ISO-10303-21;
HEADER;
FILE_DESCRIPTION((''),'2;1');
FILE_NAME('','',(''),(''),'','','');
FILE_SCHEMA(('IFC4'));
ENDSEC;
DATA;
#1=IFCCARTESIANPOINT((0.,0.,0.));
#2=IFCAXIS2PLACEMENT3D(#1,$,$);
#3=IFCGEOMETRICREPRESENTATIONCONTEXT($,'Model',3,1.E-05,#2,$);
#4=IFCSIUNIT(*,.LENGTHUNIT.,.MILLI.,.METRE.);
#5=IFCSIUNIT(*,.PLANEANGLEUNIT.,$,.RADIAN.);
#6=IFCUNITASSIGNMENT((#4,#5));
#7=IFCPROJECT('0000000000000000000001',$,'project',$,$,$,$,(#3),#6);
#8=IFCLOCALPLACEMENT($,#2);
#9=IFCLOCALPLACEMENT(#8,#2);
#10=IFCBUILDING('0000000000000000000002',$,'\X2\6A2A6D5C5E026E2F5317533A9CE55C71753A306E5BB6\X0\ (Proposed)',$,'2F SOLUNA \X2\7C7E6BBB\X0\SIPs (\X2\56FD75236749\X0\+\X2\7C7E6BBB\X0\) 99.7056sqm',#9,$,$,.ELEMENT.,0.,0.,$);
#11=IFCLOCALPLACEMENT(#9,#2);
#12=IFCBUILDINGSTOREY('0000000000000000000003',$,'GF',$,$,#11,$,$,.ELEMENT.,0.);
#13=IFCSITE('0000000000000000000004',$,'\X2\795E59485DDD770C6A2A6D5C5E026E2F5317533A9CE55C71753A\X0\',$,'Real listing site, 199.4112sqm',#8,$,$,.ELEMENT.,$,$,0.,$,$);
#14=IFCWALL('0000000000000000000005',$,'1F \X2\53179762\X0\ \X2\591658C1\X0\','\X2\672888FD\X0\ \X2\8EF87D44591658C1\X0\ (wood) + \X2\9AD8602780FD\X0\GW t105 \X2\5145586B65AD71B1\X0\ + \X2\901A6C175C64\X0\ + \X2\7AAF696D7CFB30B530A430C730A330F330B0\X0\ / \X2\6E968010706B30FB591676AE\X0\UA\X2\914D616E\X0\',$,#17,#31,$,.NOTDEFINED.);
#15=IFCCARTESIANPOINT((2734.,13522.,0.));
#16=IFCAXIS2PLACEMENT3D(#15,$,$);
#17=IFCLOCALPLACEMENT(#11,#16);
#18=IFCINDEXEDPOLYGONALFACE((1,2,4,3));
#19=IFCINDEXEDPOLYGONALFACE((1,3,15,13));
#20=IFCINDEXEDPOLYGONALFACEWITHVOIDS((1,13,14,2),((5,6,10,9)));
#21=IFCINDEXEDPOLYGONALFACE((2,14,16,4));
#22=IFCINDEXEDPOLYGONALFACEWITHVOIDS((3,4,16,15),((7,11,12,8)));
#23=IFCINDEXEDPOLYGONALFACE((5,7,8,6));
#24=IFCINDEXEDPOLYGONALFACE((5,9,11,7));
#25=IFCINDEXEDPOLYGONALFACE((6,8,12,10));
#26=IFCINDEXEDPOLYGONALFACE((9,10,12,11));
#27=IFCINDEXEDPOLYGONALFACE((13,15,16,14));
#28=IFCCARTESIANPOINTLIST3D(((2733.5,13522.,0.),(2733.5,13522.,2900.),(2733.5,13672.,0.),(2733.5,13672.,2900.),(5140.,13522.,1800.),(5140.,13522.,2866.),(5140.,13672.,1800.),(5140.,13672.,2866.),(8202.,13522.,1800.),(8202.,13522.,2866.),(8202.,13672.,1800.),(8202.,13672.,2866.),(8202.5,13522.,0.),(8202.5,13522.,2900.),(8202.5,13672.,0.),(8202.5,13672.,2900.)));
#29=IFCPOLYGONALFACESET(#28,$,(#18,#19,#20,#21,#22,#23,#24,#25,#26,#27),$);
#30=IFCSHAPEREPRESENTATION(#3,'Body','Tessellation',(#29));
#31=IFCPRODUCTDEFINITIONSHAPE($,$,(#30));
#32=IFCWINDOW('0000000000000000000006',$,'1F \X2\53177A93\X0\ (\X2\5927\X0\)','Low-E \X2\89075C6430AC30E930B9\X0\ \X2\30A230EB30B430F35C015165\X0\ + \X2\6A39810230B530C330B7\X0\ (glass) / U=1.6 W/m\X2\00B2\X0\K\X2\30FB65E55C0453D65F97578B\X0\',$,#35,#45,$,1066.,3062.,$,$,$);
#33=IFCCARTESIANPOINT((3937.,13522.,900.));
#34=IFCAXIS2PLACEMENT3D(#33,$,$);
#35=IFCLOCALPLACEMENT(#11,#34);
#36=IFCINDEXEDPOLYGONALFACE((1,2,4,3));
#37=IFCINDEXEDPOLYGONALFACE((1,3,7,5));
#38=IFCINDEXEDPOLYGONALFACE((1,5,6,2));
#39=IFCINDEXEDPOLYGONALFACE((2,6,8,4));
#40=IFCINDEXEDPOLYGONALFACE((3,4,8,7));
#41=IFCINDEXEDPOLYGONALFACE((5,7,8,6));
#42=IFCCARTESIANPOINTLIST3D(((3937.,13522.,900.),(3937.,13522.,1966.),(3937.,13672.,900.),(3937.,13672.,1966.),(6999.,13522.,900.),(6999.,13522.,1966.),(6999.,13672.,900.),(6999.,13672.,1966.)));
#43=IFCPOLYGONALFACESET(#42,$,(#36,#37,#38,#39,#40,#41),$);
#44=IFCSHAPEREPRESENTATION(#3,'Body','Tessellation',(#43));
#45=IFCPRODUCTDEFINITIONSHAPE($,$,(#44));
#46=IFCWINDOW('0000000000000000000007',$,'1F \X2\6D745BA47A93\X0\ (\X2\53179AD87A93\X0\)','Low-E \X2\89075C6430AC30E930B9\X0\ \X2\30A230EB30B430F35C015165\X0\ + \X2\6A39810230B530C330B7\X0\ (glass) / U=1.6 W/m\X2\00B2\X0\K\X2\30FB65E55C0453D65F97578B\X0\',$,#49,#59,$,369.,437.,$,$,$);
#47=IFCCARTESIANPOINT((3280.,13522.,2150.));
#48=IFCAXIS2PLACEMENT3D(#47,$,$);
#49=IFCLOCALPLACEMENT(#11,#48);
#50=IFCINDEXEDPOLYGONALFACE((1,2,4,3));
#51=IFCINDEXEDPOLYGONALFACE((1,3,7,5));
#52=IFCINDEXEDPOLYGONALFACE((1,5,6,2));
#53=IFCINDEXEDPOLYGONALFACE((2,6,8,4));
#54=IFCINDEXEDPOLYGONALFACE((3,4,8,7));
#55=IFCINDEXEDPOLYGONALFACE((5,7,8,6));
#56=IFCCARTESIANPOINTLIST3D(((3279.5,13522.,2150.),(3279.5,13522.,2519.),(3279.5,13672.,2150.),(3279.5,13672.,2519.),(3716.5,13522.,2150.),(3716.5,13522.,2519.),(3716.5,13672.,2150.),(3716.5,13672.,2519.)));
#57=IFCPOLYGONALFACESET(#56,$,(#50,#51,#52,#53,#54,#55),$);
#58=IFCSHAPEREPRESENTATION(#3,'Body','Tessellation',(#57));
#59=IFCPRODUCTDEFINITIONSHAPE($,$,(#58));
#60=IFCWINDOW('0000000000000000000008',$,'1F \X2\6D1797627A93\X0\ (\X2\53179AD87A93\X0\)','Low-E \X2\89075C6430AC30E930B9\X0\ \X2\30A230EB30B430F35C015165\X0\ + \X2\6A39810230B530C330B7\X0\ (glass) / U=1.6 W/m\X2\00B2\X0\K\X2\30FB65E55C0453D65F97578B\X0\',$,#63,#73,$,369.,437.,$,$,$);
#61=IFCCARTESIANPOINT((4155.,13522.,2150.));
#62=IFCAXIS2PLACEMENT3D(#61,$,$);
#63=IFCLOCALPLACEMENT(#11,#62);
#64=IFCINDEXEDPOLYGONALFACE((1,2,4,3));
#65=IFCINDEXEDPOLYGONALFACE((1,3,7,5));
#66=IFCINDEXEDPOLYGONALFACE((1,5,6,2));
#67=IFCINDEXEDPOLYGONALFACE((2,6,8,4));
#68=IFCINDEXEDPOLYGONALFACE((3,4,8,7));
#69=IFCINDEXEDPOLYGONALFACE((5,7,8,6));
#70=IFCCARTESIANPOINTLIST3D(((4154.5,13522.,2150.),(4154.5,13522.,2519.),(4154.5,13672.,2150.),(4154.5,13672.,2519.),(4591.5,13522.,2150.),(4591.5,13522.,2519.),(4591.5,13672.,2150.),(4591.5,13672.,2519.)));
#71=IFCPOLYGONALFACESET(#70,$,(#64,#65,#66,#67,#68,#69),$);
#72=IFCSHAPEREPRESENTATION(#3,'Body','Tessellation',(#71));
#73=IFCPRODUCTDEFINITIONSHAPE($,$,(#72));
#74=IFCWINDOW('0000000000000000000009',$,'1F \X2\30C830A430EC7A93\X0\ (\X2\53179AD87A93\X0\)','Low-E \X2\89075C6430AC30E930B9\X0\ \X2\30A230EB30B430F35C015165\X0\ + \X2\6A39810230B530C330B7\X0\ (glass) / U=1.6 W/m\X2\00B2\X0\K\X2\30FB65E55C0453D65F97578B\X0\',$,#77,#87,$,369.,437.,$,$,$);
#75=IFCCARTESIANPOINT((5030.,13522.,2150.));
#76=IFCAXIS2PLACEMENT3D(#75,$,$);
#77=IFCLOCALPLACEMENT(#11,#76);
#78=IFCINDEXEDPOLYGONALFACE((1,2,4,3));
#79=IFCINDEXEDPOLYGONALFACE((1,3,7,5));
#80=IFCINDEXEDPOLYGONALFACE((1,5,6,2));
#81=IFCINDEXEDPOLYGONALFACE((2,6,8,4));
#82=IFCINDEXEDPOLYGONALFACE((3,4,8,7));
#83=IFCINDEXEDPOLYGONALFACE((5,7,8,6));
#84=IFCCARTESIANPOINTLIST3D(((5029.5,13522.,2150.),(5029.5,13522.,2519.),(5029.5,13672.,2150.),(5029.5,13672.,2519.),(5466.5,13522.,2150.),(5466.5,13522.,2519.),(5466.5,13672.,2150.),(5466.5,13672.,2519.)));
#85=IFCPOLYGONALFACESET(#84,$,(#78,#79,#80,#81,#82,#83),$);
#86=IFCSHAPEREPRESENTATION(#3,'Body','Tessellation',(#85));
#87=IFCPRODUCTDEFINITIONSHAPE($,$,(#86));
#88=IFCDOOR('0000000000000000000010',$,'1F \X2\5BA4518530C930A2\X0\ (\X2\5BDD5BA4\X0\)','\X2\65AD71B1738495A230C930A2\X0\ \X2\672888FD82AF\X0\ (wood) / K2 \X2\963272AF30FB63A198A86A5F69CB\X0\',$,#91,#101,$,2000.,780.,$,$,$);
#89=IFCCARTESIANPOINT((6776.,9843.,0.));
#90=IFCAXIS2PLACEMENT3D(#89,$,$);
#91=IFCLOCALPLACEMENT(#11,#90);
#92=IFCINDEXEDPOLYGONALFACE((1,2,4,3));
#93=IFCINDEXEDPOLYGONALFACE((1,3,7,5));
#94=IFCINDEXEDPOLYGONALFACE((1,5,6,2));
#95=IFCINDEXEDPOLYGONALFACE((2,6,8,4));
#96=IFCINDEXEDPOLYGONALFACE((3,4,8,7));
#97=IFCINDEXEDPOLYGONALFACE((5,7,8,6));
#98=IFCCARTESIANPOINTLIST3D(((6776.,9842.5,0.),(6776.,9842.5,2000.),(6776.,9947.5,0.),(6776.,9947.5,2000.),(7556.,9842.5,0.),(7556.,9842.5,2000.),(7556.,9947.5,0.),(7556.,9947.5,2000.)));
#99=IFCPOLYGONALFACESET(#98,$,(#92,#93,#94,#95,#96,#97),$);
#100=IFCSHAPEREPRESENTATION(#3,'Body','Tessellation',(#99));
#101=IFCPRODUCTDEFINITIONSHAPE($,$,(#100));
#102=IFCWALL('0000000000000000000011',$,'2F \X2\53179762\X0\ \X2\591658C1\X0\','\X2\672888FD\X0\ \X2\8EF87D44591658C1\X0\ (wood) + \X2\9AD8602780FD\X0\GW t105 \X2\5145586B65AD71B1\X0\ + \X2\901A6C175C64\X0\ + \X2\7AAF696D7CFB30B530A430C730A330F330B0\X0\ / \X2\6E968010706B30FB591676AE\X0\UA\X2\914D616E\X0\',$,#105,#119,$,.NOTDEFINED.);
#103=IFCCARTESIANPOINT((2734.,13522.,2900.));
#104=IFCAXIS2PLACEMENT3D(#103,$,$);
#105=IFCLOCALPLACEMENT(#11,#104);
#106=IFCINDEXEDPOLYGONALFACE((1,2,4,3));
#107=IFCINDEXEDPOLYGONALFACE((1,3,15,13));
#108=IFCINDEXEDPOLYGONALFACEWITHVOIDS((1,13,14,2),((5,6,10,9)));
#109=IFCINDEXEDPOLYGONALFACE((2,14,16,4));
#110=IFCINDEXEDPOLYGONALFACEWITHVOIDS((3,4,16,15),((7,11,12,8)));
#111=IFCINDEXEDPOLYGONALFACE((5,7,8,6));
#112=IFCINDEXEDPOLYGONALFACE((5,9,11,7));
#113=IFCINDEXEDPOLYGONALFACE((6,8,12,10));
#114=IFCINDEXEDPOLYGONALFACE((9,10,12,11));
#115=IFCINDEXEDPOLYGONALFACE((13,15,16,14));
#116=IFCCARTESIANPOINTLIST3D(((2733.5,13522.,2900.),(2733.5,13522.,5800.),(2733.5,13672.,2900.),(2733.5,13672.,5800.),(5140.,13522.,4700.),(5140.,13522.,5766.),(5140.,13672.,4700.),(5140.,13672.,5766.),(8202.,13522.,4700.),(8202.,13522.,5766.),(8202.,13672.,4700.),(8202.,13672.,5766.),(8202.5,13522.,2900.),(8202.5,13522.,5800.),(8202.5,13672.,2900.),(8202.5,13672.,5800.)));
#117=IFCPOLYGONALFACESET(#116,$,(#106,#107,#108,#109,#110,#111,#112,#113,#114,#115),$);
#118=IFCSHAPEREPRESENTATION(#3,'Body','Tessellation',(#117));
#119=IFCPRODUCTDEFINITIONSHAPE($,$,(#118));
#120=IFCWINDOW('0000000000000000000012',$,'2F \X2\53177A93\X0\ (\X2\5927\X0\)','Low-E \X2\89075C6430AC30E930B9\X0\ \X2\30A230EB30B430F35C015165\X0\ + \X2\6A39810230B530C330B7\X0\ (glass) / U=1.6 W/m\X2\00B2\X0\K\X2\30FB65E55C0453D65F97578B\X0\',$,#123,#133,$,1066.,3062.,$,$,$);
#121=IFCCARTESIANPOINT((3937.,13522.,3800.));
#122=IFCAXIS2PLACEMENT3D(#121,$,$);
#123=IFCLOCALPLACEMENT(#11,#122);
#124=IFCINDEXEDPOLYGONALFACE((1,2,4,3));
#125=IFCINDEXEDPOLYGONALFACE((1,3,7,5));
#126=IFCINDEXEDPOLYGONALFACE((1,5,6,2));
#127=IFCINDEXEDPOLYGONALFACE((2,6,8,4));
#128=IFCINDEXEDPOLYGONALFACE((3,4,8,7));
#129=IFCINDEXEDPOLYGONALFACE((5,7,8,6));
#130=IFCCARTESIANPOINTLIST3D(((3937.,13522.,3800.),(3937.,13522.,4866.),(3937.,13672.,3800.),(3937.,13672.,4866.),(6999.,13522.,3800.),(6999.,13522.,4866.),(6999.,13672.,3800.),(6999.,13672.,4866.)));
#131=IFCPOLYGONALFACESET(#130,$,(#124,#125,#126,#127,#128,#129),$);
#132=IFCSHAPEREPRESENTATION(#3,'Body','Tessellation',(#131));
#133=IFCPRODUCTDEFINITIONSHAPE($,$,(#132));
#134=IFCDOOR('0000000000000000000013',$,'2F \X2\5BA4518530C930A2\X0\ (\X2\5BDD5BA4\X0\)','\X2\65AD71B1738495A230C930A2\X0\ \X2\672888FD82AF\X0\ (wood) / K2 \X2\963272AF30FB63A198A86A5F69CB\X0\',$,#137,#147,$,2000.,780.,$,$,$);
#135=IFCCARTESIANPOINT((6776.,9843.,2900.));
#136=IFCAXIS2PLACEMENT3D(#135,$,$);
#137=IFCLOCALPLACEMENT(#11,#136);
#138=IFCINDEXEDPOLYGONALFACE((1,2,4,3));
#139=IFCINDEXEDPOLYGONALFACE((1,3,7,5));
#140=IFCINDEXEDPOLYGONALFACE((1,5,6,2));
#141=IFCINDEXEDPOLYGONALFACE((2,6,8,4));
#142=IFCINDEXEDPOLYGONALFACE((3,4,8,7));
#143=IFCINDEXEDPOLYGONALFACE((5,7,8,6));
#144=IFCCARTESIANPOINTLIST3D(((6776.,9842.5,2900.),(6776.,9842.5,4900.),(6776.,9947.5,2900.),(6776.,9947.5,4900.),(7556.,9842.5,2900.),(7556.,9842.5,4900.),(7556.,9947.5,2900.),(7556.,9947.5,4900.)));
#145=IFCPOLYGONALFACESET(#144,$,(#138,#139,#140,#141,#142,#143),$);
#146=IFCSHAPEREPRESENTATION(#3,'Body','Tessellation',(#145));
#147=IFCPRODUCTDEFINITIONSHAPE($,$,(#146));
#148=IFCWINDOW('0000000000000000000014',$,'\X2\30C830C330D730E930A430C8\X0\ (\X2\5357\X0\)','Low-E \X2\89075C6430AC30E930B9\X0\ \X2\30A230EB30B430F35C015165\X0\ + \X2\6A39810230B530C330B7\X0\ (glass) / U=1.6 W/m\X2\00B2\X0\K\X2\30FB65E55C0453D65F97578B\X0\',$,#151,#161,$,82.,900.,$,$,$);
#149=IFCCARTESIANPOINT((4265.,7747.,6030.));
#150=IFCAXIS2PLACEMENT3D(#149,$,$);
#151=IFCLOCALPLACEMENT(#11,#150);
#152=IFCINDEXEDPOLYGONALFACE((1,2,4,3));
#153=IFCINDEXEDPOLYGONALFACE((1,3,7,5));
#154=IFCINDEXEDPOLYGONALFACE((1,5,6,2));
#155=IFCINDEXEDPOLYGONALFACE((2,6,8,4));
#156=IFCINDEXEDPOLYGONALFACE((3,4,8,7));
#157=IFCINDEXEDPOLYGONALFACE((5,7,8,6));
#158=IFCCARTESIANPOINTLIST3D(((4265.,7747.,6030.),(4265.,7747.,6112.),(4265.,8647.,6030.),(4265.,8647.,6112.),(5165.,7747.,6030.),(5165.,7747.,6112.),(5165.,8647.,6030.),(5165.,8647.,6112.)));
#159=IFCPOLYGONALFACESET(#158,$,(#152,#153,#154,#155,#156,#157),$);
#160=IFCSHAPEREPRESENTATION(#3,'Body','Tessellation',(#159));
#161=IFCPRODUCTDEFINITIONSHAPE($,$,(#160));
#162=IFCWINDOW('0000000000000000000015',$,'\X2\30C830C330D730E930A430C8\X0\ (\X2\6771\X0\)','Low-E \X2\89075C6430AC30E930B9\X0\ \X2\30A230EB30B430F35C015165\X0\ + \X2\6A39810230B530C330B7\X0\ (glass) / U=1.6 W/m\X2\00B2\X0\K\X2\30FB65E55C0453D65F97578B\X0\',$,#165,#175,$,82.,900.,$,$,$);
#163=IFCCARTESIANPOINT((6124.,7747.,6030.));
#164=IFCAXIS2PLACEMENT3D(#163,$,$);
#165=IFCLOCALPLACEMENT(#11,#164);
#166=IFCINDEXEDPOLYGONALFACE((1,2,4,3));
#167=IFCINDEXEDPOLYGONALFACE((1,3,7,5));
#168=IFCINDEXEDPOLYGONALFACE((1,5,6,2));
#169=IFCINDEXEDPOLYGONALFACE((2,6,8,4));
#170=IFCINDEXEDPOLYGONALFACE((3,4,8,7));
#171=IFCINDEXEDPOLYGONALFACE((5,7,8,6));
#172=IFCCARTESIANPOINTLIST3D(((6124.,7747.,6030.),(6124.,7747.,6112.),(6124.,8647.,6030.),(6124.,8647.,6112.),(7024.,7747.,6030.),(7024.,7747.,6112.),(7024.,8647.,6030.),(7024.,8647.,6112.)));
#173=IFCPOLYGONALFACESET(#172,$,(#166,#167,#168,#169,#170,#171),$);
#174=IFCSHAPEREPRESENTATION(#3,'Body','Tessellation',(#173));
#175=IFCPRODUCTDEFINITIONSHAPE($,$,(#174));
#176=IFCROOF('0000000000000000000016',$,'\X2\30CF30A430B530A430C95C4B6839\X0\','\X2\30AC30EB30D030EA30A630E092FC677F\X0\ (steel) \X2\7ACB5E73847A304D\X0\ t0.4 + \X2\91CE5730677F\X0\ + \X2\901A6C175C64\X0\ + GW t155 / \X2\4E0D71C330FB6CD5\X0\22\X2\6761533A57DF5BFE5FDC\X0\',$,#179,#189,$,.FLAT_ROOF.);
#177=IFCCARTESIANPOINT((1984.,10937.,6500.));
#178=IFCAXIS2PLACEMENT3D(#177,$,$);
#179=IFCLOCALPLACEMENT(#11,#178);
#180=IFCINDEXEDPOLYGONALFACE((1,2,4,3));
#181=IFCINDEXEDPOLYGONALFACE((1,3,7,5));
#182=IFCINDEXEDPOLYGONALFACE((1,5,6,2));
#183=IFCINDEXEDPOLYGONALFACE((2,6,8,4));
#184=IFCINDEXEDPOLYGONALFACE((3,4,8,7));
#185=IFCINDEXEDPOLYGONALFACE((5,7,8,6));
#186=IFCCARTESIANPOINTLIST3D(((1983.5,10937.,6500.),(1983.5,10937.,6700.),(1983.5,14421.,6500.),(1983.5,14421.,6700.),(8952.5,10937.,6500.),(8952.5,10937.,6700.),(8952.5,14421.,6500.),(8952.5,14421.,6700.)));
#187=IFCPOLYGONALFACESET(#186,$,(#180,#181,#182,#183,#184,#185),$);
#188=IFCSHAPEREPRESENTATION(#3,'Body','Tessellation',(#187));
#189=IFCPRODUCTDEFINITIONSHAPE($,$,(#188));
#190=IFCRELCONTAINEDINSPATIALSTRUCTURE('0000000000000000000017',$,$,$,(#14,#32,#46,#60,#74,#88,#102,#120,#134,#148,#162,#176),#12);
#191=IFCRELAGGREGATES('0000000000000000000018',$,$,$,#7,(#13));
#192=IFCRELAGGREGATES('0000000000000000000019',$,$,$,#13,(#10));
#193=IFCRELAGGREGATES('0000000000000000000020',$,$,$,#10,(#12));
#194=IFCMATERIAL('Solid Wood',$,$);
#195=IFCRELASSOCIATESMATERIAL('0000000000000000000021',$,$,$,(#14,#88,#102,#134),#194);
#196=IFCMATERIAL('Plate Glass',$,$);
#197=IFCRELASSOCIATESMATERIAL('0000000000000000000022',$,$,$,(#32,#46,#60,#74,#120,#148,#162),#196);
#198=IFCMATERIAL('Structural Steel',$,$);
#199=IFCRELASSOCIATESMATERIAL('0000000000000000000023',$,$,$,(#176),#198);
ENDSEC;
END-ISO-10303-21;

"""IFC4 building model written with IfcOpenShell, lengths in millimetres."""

from ifc_helpers import new_model, si_unit, frame, frame_2d, origin, place, context, project, spatial, rectangle, extrude, material, element, fill, save


model = new_model("IFC4")

# Units and contexts
model_context = context("Model", 3, precision=1e-05, world=origin())
ifc_project = project(units=[si_unit("LENGTHUNIT", "METRE", prefix="MILLI"), si_unit("PLANEANGLEUNIT", "RADIAN")], contexts=[model_context])

# Site, building, storey
site_placement = place(None, origin())
site = spatial("IfcSite", under=ifc_project, at=site_placement, Name="神奈川県横浜市港北区鳥山町", ObjectType="Real listing site, 199.4112sqm", CompositionType="ELEMENT", RefElevation=0.0)
building_placement = place(site_placement, origin())
building = spatial("IfcBuilding", under=site, at=building_placement, Name="横浜市港北区鳥山町の家 (Proposed)", ObjectType="2F SOLUNA 籾殻SIPs (国産杉+籾殻) 99.7056sqm", CompositionType="ELEMENT", ElevationOfRefHeight=0.0, ElevationOfTerrain=0.0)
storey_placement = place(building_placement, origin())
storey = spatial("IfcBuildingStorey", under=building, at=storey_placement, Name="GF", CompositionType="ELEMENT", Elevation=0.0)

# Wall, openings, windows
ifc_material_1 = material(Name="Solid Wood")
wall_1_placement = place(storey_placement, frame((2734.0, 13522.0, 0.0)))
wall_1 = element("IfcWall", 1, at=wall_1_placement, inside=storey, material=ifc_material_1, Name="1F 北面 外壁", Description="木製 軸組外壁 (wood) + 高性能GW t105 充填断熱 + 通気層 + 窯業系サイディング / 準耐火・外皮UA配慮", PredefinedType="NOTDEFINED", context=model_context, shape_type="SweptSolid", body=[
    extrude(rectangle(XDim=5469.0, YDim=150.0, at=frame_2d((2734.0, 75.0))), frame((2734.0, 13522.0, 0.0)), (0.0, 0.0, 1.0), 2900.0),
])
opening_1_placement = place(storey_placement, frame((3937.0, 13522.0, 900.0)))
opening_1 = element("IfcOpeningElement", 2, at=opening_1_placement, cuts=wall_1, PredefinedType="NOTDEFINED", context=model_context, shape_type="SweptSolid", body=[
    extrude(rectangle(XDim=3062.0, YDim=150.0, at=frame_2d((1531.0, 75.0))), frame((3937.0, 13522.0, 900.0)), (0.0, 0.0, 1.0), 1066.0),
])
opening_2_placement = place(storey_placement, frame((3280.0, 13522.0, 2150.0)))
opening_2 = element("IfcOpeningElement", 3, at=opening_2_placement, cuts=wall_1, PredefinedType="NOTDEFINED", context=model_context, shape_type="SweptSolid", body=[
    extrude(rectangle(XDim=437.0, YDim=150.0, at=frame_2d((218.0, 75.0))), frame((3280.0, 13522.0, 2150.0)), (0.0, 0.0, 1.0), 369.0),
])
opening_3_placement = place(storey_placement, frame((4155.0, 13522.0, 2150.0)))
opening_3 = element("IfcOpeningElement", 4, at=opening_3_placement, cuts=wall_1, PredefinedType="NOTDEFINED", context=model_context, shape_type="SweptSolid", body=[
    extrude(rectangle(XDim=437.0, YDim=150.0, at=frame_2d((218.0, 75.0))), frame((4155.0, 13522.0, 2150.0)), (0.0, 0.0, 1.0), 369.0),
])
opening_4_placement = place(storey_placement, frame((5030.0, 13522.0, 2150.0)))
opening_4 = element("IfcOpeningElement", 5, at=opening_4_placement, cuts=wall_1, PredefinedType="NOTDEFINED", context=model_context, shape_type="SweptSolid", body=[
    extrude(rectangle(XDim=437.0, YDim=150.0, at=frame_2d((218.0, 75.0))), frame((5030.0, 13522.0, 2150.0)), (0.0, 0.0, 1.0), 369.0),
])
ifc_material_2 = material(Name="Plate Glass")
window_1_placement = place(storey_placement, frame((3937.0, 13522.0, 900.0)))
window_1 = element("IfcWindow", 6, at=window_1_placement, inside=storey, material=ifc_material_2, Name="1F 北窓 (大)", Description="Low-E 複層ガラス アルゴン封入 + 樹脂サッシ (glass) / U=1.6 W/m²K・日射取得型", OverallHeight=1066.0, OverallWidth=3062.0, context=model_context, shape_type="SweptSolid", body=[
    extrude(rectangle(XDim=3062.0, YDim=150.0, at=frame_2d((1531.0, 75.0))), frame((3937.0, 13522.0, 900.0)), (0.0, 0.0, 1.0), 1066.0),
])
fill(opening_1, window_1)
window_2_placement = place(storey_placement, frame((3280.0, 13522.0, 2150.0)))
window_2 = element("IfcWindow", 7, at=window_2_placement, inside=storey, material=ifc_material_2, Name="1F 浴室窓 (北高窓)", Description="Low-E 複層ガラス アルゴン封入 + 樹脂サッシ (glass) / U=1.6 W/m²K・日射取得型", OverallHeight=369.0, OverallWidth=437.0, context=model_context, shape_type="SweptSolid", body=[
    extrude(rectangle(XDim=437.0, YDim=150.0, at=frame_2d((218.0, 75.0))), frame((3280.0, 13522.0, 2150.0)), (0.0, 0.0, 1.0), 369.0),
])
fill(opening_2, window_2)
window_3_placement = place(storey_placement, frame((4155.0, 13522.0, 2150.0)))
window_3 = element("IfcWindow", 8, at=window_3_placement, inside=storey, material=ifc_material_2, Name="1F 洗面窓 (北高窓)", Description="Low-E 複層ガラス アルゴン封入 + 樹脂サッシ (glass) / U=1.6 W/m²K・日射取得型", OverallHeight=369.0, OverallWidth=437.0, context=model_context, shape_type="SweptSolid", body=[
    extrude(rectangle(XDim=437.0, YDim=150.0, at=frame_2d((218.0, 75.0))), frame((4155.0, 13522.0, 2150.0)), (0.0, 0.0, 1.0), 369.0),
])
fill(opening_3, window_3)
window_4_placement = place(storey_placement, frame((5030.0, 13522.0, 2150.0)))
window_4 = element("IfcWindow", 9, at=window_4_placement, inside=storey, material=ifc_material_2, Name="1F トイレ窓 (北高窓)", Description="Low-E 複層ガラス アルゴン封入 + 樹脂サッシ (glass) / U=1.6 W/m²K・日射取得型", OverallHeight=369.0, OverallWidth=437.0, context=model_context, shape_type="SweptSolid", body=[
    extrude(rectangle(XDim=437.0, YDim=150.0, at=frame_2d((218.0, 75.0))), frame((5030.0, 13522.0, 2150.0)), (0.0, 0.0, 1.0), 369.0),
])
fill(opening_4, window_4)

# Door
door_1_placement = place(storey_placement, frame((6776.0, 9843.0, 0.0)))
element("IfcDoor", 10, at=door_1_placement, inside=storey, material=ifc_material_1, Name="1F 室内ドア (寝室)", Description="断熱玄関ドア 木製芯 (wood) / K2 防犯・採風機構", OverallHeight=2000.0, OverallWidth=780.0, context=model_context, shape_type="SweptSolid", body=[
    extrude(rectangle(XDim=780.0, YDim=105.0, at=frame_2d((390.0, 52.0))), frame((6776.0, 9843.0, 0.0)), (0.0, 0.0, 1.0), 2000.0),
])

# Wall, opening, window
wall_2_placement = place(storey_placement, frame((2734.0, 13522.0, 2900.0)))
wall_2 = element("IfcWall", 11, at=wall_2_placement, inside=storey, material=ifc_material_1, Name="2F 北面 外壁", Description="木製 軸組外壁 (wood) + 高性能GW t105 充填断熱 + 通気層 + 窯業系サイディング / 準耐火・外皮UA配慮", PredefinedType="NOTDEFINED", context=model_context, shape_type="SweptSolid", body=[
    extrude(rectangle(XDim=5469.0, YDim=150.0, at=frame_2d((2734.0, 75.0))), frame((2734.0, 13522.0, 2900.0)), (0.0, 0.0, 1.0), 2900.0),
])
opening_5_placement = place(storey_placement, frame((3937.0, 13522.0, 3800.0)))
opening_5 = element("IfcOpeningElement", 12, at=opening_5_placement, cuts=wall_2, PredefinedType="NOTDEFINED", context=model_context, shape_type="SweptSolid", body=[
    extrude(rectangle(XDim=3062.0, YDim=150.0, at=frame_2d((1531.0, 75.0))), frame((3937.0, 13522.0, 3800.0)), (0.0, 0.0, 1.0), 1066.0),
])
window_5_placement = place(storey_placement, frame((3937.0, 13522.0, 3800.0)))
window_5 = element("IfcWindow", 13, at=window_5_placement, inside=storey, material=ifc_material_2, Name="2F 北窓 (大)", Description="Low-E 複層ガラス アルゴン封入 + 樹脂サッシ (glass) / U=1.6 W/m²K・日射取得型", OverallHeight=1066.0, OverallWidth=3062.0, context=model_context, shape_type="SweptSolid", body=[
    extrude(rectangle(XDim=3062.0, YDim=150.0, at=frame_2d((1531.0, 75.0))), frame((3937.0, 13522.0, 3800.0)), (0.0, 0.0, 1.0), 1066.0),
])
fill(opening_5, window_5)

# Door
door_2_placement = place(storey_placement, frame((6776.0, 9843.0, 2900.0)))
element("IfcDoor", 14, at=door_2_placement, inside=storey, material=ifc_material_1, Name="2F 室内ドア (寝室)", Description="断熱玄関ドア 木製芯 (wood) / K2 防犯・採風機構", OverallHeight=2000.0, OverallWidth=780.0, context=model_context, shape_type="SweptSolid", body=[
    extrude(rectangle(XDim=780.0, YDim=105.0, at=frame_2d((390.0, 52.0))), frame((6776.0, 9843.0, 2900.0)), (0.0, 0.0, 1.0), 2000.0),
])

# Windows
window_6_placement = place(storey_placement, frame((4265.0, 7747.0, 6030.0)))
element("IfcWindow", 15, at=window_6_placement, inside=storey, material=ifc_material_2, Name="トップライト (南)", Description="Low-E 複層ガラス アルゴン封入 + 樹脂サッシ (glass) / U=1.6 W/m²K・日射取得型", OverallHeight=82.0, OverallWidth=900.0, context=model_context, shape_type="SweptSolid", body=[
    extrude(rectangle(XDim=900.0, YDim=900.0, at=frame_2d((450.0, 450.0))), frame((4265.0, 7747.0, 6030.0)), (0.0, 0.0, 1.0), 82.0),
])
window_7_placement = place(storey_placement, frame((6124.0, 7747.0, 6030.0)))
element("IfcWindow", 16, at=window_7_placement, inside=storey, material=ifc_material_2, Name="トップライト (東)", Description="Low-E 複層ガラス アルゴン封入 + 樹脂サッシ (glass) / U=1.6 W/m²K・日射取得型", OverallHeight=82.0, OverallWidth=900.0, context=model_context, shape_type="SweptSolid", body=[
    extrude(rectangle(XDim=900.0, YDim=900.0, at=frame_2d((450.0, 450.0))), frame((6124.0, 7747.0, 6030.0)), (0.0, 0.0, 1.0), 82.0),
])

# Roof
ifc_material_3 = material(Name="Structural Steel")
roof_placement = place(storey_placement, frame((1984.0, 10937.0, 6500.0)))
element("IfcRoof", 17, at=roof_placement, inside=storey, material=ifc_material_3, Name="ハイサイド屋根", Description="ガルバリウム鋼板 (steel) 立平葺き t0.4 + 野地板 + 通気層 + GW t155 / 不燃・法22条区域対応", PredefinedType="FLAT_ROOF", context=model_context, shape_type="SweptSolid", body=[
    extrude(rectangle(XDim=6969.0, YDim=3484.0, at=frame_2d((3484.0, 1742.0))), frame((1984.0, 10937.0, 6500.0)), (0.0, 0.0, 1.0), 200.0),
])

save(model, "model.ifc")
